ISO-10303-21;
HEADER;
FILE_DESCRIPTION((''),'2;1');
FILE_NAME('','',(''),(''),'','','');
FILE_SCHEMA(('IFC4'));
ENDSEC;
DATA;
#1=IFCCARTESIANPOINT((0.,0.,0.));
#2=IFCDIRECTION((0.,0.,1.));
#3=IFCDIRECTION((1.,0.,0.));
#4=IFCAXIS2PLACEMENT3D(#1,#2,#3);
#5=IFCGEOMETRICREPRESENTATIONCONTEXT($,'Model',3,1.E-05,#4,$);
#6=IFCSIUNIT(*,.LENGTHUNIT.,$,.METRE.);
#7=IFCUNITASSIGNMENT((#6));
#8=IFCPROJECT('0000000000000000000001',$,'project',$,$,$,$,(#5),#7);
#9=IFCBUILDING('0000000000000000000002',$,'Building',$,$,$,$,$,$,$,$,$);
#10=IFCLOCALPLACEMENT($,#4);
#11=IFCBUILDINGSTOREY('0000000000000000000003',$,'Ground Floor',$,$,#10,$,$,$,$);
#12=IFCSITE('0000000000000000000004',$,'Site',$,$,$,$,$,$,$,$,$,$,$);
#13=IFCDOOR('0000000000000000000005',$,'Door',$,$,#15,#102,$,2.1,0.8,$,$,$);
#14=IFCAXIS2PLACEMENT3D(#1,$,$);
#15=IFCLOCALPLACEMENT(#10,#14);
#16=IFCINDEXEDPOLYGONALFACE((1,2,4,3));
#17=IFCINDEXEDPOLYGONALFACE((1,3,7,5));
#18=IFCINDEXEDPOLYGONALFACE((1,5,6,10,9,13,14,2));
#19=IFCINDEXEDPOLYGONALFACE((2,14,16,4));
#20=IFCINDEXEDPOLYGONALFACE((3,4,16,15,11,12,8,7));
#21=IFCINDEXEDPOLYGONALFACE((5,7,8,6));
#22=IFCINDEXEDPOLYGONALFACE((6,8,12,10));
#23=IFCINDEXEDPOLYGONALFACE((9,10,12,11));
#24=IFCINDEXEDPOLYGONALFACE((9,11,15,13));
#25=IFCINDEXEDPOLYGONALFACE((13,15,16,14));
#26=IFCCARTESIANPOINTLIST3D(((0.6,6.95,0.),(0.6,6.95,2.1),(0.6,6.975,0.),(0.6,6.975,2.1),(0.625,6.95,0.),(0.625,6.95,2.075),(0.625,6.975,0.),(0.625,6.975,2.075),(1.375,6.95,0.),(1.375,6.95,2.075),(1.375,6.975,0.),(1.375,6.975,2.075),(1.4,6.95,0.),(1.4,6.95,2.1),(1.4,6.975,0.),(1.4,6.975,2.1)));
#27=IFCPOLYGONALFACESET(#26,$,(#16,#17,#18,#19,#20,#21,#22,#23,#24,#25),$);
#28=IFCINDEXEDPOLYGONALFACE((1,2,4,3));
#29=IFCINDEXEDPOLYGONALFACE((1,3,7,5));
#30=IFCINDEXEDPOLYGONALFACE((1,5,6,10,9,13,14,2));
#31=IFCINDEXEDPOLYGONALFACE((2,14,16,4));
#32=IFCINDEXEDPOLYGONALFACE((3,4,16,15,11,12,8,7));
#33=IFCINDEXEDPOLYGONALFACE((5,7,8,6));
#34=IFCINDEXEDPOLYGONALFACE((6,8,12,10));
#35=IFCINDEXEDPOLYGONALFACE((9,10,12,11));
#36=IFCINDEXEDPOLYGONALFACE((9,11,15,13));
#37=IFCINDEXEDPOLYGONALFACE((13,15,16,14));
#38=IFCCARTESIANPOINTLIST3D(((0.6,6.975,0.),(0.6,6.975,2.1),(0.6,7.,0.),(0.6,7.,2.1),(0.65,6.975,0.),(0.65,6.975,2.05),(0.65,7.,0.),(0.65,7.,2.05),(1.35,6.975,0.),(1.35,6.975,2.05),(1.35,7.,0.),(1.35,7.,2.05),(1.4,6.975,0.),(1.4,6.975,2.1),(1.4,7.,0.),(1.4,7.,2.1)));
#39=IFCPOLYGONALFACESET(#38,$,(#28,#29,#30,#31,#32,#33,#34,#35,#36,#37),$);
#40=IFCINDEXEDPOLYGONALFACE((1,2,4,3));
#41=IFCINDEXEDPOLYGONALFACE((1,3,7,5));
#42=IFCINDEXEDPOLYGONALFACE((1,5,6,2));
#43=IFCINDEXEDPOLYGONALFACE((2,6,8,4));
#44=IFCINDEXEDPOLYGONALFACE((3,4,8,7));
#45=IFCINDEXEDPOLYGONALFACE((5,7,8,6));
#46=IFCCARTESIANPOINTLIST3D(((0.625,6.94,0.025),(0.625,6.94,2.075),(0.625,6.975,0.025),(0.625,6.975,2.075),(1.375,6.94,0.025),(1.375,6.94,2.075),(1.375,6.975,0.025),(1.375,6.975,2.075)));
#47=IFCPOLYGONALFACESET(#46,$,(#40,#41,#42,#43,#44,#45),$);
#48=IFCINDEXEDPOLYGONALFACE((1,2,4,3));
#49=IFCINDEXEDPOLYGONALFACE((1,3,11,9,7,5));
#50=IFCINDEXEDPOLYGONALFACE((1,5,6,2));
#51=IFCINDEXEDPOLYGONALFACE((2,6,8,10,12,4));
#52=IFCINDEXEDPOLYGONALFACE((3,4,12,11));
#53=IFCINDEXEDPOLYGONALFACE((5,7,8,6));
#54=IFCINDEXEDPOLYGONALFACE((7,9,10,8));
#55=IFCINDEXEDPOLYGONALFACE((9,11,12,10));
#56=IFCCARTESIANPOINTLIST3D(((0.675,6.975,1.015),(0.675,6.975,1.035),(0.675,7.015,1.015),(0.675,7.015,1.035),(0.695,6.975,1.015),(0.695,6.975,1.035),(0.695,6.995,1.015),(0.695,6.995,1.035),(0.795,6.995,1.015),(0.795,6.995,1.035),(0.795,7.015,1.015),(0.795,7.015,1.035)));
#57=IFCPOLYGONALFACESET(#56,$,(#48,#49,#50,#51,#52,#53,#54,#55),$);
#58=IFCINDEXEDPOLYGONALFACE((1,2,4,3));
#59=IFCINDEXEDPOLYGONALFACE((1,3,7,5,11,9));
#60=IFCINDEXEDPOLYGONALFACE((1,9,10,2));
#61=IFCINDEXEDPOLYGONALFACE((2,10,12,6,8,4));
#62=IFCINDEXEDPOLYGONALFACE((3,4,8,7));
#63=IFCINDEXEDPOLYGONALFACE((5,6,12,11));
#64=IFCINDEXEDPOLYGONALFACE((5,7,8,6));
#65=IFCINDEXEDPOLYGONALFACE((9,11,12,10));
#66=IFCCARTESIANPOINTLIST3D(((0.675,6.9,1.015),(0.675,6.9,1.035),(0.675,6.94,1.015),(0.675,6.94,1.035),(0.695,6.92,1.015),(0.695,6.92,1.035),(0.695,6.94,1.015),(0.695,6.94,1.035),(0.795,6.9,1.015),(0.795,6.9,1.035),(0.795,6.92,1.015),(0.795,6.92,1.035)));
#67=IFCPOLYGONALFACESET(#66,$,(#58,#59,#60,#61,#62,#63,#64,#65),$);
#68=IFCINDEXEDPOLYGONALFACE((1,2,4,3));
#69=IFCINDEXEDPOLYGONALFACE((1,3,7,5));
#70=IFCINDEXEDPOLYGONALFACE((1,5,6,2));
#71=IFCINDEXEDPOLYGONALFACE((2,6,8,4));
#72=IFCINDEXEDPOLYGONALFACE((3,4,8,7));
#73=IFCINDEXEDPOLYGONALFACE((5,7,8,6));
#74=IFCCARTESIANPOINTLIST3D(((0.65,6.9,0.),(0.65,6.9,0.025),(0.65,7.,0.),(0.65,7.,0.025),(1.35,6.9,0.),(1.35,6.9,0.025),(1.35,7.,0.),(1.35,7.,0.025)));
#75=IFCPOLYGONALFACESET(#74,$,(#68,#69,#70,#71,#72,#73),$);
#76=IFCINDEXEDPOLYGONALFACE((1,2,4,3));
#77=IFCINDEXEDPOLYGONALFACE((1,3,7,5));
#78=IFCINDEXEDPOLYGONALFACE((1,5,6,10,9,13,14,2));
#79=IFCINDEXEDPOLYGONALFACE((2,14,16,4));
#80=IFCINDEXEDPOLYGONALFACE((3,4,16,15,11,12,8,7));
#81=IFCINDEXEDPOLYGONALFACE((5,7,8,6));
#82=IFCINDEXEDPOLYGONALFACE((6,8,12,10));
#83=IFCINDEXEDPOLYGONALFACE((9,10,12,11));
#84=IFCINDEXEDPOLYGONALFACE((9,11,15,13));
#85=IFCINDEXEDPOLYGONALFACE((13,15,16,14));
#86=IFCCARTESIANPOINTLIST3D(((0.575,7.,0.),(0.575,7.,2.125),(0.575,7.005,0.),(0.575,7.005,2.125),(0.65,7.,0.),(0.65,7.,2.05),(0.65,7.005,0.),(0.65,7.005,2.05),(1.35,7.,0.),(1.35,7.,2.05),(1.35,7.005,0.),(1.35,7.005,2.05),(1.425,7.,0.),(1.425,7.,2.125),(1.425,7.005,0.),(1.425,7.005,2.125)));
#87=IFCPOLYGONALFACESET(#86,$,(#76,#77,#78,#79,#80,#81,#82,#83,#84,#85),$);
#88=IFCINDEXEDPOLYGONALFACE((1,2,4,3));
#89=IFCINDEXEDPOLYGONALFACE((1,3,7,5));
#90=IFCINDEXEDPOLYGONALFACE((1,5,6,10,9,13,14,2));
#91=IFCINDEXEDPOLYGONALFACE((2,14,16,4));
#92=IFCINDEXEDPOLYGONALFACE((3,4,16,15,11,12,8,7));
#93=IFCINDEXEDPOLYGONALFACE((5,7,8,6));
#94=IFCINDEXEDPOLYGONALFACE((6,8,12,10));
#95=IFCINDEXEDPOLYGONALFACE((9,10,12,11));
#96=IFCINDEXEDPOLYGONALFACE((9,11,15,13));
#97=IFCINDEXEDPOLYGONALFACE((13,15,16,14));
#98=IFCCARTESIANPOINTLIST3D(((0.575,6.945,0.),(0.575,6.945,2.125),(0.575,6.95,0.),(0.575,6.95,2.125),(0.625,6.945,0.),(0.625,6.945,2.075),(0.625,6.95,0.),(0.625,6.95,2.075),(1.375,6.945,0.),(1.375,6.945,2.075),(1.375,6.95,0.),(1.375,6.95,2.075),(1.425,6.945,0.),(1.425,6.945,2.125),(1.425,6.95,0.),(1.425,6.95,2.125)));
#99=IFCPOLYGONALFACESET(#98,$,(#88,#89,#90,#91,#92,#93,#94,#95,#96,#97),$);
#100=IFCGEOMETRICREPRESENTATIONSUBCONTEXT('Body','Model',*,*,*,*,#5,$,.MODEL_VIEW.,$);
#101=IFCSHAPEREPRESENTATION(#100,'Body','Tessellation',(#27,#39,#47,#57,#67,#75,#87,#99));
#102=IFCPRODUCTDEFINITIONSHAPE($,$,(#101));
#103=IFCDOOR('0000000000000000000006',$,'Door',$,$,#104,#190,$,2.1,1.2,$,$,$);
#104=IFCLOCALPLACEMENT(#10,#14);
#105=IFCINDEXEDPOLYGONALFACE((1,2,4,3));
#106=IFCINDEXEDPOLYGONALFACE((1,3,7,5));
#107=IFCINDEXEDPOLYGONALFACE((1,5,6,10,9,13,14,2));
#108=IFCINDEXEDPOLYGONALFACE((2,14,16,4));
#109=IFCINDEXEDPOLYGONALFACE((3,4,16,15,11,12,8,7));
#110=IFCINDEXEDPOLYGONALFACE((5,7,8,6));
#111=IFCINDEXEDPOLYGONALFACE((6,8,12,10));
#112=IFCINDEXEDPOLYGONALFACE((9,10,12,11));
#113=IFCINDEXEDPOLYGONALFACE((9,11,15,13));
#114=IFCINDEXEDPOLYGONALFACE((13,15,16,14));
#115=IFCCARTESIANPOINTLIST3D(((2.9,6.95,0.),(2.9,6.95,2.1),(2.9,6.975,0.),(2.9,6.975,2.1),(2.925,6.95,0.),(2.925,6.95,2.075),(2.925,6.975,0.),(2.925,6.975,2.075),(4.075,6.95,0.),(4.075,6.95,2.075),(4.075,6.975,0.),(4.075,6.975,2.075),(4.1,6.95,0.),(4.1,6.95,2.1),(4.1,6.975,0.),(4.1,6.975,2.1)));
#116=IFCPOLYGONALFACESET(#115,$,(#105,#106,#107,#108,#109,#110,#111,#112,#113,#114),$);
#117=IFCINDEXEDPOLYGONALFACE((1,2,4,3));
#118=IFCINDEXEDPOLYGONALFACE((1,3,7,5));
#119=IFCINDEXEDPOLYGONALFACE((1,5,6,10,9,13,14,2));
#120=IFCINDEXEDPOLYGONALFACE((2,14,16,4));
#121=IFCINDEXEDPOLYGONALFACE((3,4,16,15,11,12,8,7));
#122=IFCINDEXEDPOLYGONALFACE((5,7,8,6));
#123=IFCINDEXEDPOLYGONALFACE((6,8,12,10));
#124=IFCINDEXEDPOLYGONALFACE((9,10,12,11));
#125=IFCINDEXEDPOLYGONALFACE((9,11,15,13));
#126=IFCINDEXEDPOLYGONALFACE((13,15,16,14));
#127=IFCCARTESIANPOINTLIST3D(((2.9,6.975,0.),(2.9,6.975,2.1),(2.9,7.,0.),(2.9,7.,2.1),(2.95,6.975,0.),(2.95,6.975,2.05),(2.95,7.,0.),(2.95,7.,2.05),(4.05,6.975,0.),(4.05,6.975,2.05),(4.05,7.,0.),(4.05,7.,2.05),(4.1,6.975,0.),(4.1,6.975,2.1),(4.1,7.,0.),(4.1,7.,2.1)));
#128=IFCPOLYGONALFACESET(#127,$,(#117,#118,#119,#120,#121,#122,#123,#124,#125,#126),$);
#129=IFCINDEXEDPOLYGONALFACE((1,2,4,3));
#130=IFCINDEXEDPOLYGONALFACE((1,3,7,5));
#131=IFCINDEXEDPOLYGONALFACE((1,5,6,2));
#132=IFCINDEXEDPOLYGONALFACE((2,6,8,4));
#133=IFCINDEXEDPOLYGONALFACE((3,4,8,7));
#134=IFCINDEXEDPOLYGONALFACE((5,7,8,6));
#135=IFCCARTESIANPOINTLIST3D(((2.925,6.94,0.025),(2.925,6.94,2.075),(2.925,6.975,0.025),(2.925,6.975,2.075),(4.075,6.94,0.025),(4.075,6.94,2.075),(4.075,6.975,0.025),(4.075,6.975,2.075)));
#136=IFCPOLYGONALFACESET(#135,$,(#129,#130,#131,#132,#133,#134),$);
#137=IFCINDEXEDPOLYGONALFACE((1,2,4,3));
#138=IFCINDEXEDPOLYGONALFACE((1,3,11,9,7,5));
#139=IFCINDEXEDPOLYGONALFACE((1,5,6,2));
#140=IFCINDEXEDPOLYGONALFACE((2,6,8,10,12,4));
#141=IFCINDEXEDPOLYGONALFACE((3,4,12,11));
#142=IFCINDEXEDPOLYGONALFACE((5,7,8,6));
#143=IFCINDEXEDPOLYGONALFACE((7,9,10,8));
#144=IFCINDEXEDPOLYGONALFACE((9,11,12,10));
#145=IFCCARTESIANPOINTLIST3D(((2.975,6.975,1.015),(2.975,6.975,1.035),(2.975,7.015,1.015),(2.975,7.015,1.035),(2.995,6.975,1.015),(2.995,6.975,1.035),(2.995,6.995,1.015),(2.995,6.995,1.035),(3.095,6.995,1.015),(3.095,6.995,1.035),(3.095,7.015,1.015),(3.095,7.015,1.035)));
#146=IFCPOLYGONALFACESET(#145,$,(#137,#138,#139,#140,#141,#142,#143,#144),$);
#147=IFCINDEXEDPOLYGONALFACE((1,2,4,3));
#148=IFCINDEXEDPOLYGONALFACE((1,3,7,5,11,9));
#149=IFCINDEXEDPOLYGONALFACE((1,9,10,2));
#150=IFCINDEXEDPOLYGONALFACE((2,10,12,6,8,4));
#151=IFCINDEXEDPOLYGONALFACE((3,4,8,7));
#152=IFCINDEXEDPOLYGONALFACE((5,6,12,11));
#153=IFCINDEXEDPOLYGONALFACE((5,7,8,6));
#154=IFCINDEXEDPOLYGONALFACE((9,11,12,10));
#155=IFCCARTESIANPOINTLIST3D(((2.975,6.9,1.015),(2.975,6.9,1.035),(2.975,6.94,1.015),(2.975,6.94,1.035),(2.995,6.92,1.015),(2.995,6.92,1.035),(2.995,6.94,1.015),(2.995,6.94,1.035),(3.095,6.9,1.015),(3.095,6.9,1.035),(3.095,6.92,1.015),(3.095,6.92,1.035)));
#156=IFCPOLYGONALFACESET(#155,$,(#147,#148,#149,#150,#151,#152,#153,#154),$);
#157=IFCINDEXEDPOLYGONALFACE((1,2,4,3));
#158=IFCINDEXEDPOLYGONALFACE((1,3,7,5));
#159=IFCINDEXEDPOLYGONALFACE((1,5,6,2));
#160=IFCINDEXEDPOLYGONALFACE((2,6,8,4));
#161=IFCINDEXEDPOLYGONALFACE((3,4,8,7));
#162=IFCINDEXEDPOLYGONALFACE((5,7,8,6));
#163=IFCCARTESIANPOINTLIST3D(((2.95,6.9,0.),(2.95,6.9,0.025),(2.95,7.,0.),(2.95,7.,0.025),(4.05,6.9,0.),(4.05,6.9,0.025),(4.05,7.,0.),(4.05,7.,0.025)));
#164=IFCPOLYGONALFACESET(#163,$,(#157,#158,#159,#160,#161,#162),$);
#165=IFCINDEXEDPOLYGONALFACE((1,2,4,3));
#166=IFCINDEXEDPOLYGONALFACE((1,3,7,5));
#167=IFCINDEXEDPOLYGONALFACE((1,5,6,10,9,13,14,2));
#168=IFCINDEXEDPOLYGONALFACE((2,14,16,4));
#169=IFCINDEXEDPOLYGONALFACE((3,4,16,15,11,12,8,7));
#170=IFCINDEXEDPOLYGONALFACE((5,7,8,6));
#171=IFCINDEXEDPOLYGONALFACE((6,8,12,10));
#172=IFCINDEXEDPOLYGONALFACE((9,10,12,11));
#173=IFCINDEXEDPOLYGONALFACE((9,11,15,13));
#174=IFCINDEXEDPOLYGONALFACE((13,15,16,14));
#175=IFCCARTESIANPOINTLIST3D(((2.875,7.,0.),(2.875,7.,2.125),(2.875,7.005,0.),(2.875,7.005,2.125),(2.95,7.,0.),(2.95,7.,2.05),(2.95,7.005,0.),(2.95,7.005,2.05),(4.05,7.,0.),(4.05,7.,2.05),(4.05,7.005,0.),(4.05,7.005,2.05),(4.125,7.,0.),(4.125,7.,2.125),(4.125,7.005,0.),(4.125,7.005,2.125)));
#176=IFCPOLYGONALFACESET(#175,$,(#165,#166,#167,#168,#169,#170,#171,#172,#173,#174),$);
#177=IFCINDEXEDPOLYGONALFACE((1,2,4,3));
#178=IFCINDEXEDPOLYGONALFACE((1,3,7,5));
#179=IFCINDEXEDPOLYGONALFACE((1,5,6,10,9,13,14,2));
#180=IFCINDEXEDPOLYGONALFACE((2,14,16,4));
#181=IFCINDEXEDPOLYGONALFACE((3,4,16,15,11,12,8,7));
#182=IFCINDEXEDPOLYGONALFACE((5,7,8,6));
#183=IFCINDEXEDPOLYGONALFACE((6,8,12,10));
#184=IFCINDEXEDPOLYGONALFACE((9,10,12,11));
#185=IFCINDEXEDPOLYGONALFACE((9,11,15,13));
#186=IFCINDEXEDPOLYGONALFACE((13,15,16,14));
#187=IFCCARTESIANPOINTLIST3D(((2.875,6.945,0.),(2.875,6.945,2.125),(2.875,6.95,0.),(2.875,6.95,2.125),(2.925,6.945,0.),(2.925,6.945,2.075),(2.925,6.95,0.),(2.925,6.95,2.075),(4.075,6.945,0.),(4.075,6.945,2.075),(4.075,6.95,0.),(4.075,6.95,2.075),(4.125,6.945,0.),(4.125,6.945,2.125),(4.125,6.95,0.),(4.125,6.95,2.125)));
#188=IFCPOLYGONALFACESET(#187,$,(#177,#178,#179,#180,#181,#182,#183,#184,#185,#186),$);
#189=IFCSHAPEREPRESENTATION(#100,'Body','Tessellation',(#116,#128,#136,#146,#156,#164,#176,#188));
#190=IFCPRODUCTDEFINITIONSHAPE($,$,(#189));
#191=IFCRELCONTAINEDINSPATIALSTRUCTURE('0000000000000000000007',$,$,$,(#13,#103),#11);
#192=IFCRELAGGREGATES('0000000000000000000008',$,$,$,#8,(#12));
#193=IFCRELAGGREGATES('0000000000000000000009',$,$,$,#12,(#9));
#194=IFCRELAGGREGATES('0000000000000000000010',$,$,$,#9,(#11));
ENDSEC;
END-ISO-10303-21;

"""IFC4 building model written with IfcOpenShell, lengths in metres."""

from ifc_helpers import new_model, si_unit, frame, origin_with_axes, place, context, subcontext, project, spatial, line, indexed_curve, outline, extrude, element, save


model = new_model("IFC4")

# Units and contexts
model_context = context("Model", 3, precision=1e-05, world=origin_with_axes())
body_context = subcontext(model_context, "Body", "Model", "MODEL_VIEW")
ifc_project = project(units=[si_unit("LENGTHUNIT", "METRE")], contexts=[model_context])

# Site, building, storey
site = spatial("IfcSite", under=ifc_project, Name="Site")
building = spatial("IfcBuilding", under=site, Name="Building")
storey_placement = place(None, origin_with_axes())
storey = spatial("IfcBuildingStorey", under=building, at=storey_placement, Name="Ground Floor")

# Doors
door_1_placement = place(storey_placement, frame((1.4, 7.0, 0.0), z_axis=(0.0, 0.0, 1.0), x_axis=(-1.0, 0.0, 0.0)))
element("IfcDoor", 1, at=door_1_placement, inside=storey, Name="Door", OverallHeight=2.1, OverallWidth=0.8, context=body_context, shape_type="SweptSolid", body=[
    extrude(outline(indexed_curve([(0.0, 0.0), (0.0, 2.1), (0.8, 2.1), (0.8, 0.0), (0.775, 0.0), (0.775, 2.075), (0.025, 2.075), (0.025, 0.0)], segments=[line(1, 2, 3, 4, 5, 6, 7, 8, 1)])), frame((0.0, 0.025, 0.0), z_axis=(0.0, -1.0, 0.0), x_axis=(1.0, 0.0, 0.0)), (0.0, 0.0, -1.0), 0.025),
    extrude(outline(indexed_curve([(0.0, 0.0), (0.0, 2.1), (0.8, 2.1), (0.8, 0.0), (0.75, 0.0), (0.75, 2.05), (0.05, 2.05), (0.05, 0.0)], segments=[line(1, 2, 3, 4, 5, 6, 7, 8, 1)])), frame((0.0, 0.0, 0.0), z_axis=(0.0, -1.0, 0.0), x_axis=(1.0, 0.0, 0.0)), (0.0, 0.0, -1.0), 0.025),
    extrude(outline(indexed_curve([(0.0, 0.0), (0.75, 0.0), (0.75, 0.035), (0.0, 0.035)], segments=[line(1, 2, 3, 4, 1)])), frame((0.025, 0.025, 0.025), z_axis=(0.0, 0.0, 1.0), x_axis=(1.0, 0.0, 0.0)), (0.0, 0.0, 1.0), 2.05),
    extrude(outline(indexed_curve([(0.0, 0.0), (0.0, -0.04), (-0.12, -0.04), (-0.12, -0.02), (-0.02, -0.02), (-0.02, 0.0)], segments=[line(1, 2, 3, 4, 5, 6, 1)])), frame((0.725, 0.025, 1.015), z_axis=(0.0, 0.0, 1.0), x_axis=(1.0, 0.0, 0.0)), (0.0, 0.0, 1.0), 0.02),
    extrude(outline(indexed_curve([(0.0, 0.0), (0.0, 0.04), (-0.12, 0.04), (-0.12, 0.02), (-0.02, 0.02), (-0.02, 0.0)], segments=[line(1, 2, 3, 4, 5, 6, 1)])), frame((0.725, 0.06, 1.015), z_axis=(0.0, 0.0, 1.0), x_axis=(1.0, 0.0, 0.0)), (0.0, 0.0, 1.0), 0.02),
    extrude(outline(indexed_curve([(0.0, 0.0), (0.7, 0.0), (0.7, 0.1), (0.0, 0.1)], segments=[line(1, 2, 3, 4, 1)])), frame((0.05, 0.0, 0.0), z_axis=(0.0, 0.0, 1.0), x_axis=(1.0, 0.0, 0.0)), (0.0, 0.0, 1.0), 0.025),
    extrude(outline(indexed_curve([(0.0, 0.0), (0.0, 2.125), (0.85, 2.125), (0.85, 0.0), (0.775, 0.0), (0.775, 2.05), (0.075, 2.05), (0.075, 0.0)], segments=[line(1, 2, 3, 4, 5, 6, 7, 8, 1)])), frame((-0.025, -0.005, 0.0), z_axis=(0.0, -1.0, 0.0), x_axis=(1.0, 0.0, 0.0)), (0.0, 0.0, -1.0), 0.005),
    extrude(outline(indexed_curve([(0.0, 0.0), (0.0, 2.125), (0.85, 2.125), (0.85, 0.0), (0.8, 0.0), (0.8, 2.075), (0.05, 2.075), (0.05, 0.0)], segments=[line(1, 2, 3, 4, 5, 6, 7, 8, 1)])), frame((-0.025, 0.05, 0.0), z_axis=(0.0, -1.0, 0.0), x_axis=(1.0, 0.0, 0.0)), (0.0, 0.0, -1.0), 0.005),
])
door_2_placement = place(storey_placement, frame((4.1, 7.0, 0.0), z_axis=(0.0, 0.0, 1.0), x_axis=(-1.0, 0.0, 0.0)))
element("IfcDoor", 2, at=door_2_placement, inside=storey, Name="Door", OverallHeight=2.1, OverallWidth=1.2, context=body_context, shape_type="SweptSolid", body=[
    extrude(outline(indexed_curve([(0.0, 0.0), (0.0, 2.1), (1.2, 2.1), (1.2, 0.0), (1.175, 0.0), (1.175, 2.075), (0.025, 2.075), (0.025, 0.0)], segments=[line(1, 2, 3, 4, 5, 6, 7, 8, 1)])), frame((0.0, 0.025, 0.0), z_axis=(0.0, -1.0, 0.0), x_axis=(1.0, 0.0, 0.0)), (0.0, 0.0, -1.0), 0.025),
    extrude(outline(indexed_curve([(0.0, 0.0), (0.0, 2.1), (1.2, 2.1), (1.2, 0.0), (1.15, 0.0), (1.15, 2.05), (0.05, 2.05), (0.05, 0.0)], segments=[line(1, 2, 3, 4, 5, 6, 7, 8, 1)])), frame((0.0, 0.0, 0.0), z_axis=(0.0, -1.0, 0.0), x_axis=(1.0, 0.0, 0.0)), (0.0, 0.0, -1.0), 0.025),
    extrude(outline(indexed_curve([(0.0, 0.0), (1.15, 0.0), (1.15, 0.035), (0.0, 0.035)], segments=[line(1, 2, 3, 4, 1)])), frame((0.025, 0.025, 0.025), z_axis=(0.0, 0.0, 1.0), x_axis=(1.0, 0.0, 0.0)), (0.0, 0.0, 1.0), 2.05),
    extrude(outline(indexed_curve([(0.0, 0.0), (0.0, -0.04), (-0.12, -0.04), (-0.12, -0.02), (-0.02, -0.02), (-0.02, 0.0)], segments=[line(1, 2, 3, 4, 5, 6, 1)])), frame((1.125, 0.025, 1.015), z_axis=(0.0, 0.0, 1.0), x_axis=(1.0, 0.0, 0.0)), (0.0, 0.0, 1.0), 0.02),
    extrude(outline(indexed_curve([(0.0, 0.0), (0.0, 0.04), (-0.12, 0.04), (-0.12, 0.02), (-0.02, 0.02), (-0.02, 0.0)], segments=[line(1, 2, 3, 4, 5, 6, 1)])), frame((1.125, 0.06, 1.015), z_axis=(0.0, 0.0, 1.0), x_axis=(1.0, 0.0, 0.0)), (0.0, 0.0, 1.0), 0.02),
    extrude(outline(indexed_curve([(0.0, 0.0), (1.1, 0.0), (1.1, 0.1), (0.0, 0.1)], segments=[line(1, 2, 3, 4, 1)])), frame((0.05, 0.0, 0.0), z_axis=(0.0, 0.0, 1.0), x_axis=(1.0, 0.0, 0.0)), (0.0, 0.0, 1.0), 0.025),
    extrude(outline(indexed_curve([(0.0, 0.0), (0.0, 2.125), (1.25, 2.125), (1.25, 0.0), (1.175, 0.0), (1.175, 2.05), (0.075, 2.05), (0.075, 0.0)], segments=[line(1, 2, 3, 4, 5, 6, 7, 8, 1)])), frame((-0.025, -0.005, 0.0), z_axis=(0.0, -1.0, 0.0), x_axis=(1.0, 0.0, 0.0)), (0.0, 0.0, -1.0), 0.005),
    extrude(outline(indexed_curve([(0.0, 0.0), (0.0, 2.125), (1.25, 2.125), (1.25, 0.0), (1.2, 0.0), (1.2, 2.075), (0.05, 2.075), (0.05, 0.0)], segments=[line(1, 2, 3, 4, 5, 6, 7, 8, 1)])), frame((-0.025, 0.05, 0.0), z_axis=(0.0, -1.0, 0.0), x_axis=(1.0, 0.0, 0.0)), (0.0, 0.0, -1.0), 0.005),
])

save(model, "model.ifc")
